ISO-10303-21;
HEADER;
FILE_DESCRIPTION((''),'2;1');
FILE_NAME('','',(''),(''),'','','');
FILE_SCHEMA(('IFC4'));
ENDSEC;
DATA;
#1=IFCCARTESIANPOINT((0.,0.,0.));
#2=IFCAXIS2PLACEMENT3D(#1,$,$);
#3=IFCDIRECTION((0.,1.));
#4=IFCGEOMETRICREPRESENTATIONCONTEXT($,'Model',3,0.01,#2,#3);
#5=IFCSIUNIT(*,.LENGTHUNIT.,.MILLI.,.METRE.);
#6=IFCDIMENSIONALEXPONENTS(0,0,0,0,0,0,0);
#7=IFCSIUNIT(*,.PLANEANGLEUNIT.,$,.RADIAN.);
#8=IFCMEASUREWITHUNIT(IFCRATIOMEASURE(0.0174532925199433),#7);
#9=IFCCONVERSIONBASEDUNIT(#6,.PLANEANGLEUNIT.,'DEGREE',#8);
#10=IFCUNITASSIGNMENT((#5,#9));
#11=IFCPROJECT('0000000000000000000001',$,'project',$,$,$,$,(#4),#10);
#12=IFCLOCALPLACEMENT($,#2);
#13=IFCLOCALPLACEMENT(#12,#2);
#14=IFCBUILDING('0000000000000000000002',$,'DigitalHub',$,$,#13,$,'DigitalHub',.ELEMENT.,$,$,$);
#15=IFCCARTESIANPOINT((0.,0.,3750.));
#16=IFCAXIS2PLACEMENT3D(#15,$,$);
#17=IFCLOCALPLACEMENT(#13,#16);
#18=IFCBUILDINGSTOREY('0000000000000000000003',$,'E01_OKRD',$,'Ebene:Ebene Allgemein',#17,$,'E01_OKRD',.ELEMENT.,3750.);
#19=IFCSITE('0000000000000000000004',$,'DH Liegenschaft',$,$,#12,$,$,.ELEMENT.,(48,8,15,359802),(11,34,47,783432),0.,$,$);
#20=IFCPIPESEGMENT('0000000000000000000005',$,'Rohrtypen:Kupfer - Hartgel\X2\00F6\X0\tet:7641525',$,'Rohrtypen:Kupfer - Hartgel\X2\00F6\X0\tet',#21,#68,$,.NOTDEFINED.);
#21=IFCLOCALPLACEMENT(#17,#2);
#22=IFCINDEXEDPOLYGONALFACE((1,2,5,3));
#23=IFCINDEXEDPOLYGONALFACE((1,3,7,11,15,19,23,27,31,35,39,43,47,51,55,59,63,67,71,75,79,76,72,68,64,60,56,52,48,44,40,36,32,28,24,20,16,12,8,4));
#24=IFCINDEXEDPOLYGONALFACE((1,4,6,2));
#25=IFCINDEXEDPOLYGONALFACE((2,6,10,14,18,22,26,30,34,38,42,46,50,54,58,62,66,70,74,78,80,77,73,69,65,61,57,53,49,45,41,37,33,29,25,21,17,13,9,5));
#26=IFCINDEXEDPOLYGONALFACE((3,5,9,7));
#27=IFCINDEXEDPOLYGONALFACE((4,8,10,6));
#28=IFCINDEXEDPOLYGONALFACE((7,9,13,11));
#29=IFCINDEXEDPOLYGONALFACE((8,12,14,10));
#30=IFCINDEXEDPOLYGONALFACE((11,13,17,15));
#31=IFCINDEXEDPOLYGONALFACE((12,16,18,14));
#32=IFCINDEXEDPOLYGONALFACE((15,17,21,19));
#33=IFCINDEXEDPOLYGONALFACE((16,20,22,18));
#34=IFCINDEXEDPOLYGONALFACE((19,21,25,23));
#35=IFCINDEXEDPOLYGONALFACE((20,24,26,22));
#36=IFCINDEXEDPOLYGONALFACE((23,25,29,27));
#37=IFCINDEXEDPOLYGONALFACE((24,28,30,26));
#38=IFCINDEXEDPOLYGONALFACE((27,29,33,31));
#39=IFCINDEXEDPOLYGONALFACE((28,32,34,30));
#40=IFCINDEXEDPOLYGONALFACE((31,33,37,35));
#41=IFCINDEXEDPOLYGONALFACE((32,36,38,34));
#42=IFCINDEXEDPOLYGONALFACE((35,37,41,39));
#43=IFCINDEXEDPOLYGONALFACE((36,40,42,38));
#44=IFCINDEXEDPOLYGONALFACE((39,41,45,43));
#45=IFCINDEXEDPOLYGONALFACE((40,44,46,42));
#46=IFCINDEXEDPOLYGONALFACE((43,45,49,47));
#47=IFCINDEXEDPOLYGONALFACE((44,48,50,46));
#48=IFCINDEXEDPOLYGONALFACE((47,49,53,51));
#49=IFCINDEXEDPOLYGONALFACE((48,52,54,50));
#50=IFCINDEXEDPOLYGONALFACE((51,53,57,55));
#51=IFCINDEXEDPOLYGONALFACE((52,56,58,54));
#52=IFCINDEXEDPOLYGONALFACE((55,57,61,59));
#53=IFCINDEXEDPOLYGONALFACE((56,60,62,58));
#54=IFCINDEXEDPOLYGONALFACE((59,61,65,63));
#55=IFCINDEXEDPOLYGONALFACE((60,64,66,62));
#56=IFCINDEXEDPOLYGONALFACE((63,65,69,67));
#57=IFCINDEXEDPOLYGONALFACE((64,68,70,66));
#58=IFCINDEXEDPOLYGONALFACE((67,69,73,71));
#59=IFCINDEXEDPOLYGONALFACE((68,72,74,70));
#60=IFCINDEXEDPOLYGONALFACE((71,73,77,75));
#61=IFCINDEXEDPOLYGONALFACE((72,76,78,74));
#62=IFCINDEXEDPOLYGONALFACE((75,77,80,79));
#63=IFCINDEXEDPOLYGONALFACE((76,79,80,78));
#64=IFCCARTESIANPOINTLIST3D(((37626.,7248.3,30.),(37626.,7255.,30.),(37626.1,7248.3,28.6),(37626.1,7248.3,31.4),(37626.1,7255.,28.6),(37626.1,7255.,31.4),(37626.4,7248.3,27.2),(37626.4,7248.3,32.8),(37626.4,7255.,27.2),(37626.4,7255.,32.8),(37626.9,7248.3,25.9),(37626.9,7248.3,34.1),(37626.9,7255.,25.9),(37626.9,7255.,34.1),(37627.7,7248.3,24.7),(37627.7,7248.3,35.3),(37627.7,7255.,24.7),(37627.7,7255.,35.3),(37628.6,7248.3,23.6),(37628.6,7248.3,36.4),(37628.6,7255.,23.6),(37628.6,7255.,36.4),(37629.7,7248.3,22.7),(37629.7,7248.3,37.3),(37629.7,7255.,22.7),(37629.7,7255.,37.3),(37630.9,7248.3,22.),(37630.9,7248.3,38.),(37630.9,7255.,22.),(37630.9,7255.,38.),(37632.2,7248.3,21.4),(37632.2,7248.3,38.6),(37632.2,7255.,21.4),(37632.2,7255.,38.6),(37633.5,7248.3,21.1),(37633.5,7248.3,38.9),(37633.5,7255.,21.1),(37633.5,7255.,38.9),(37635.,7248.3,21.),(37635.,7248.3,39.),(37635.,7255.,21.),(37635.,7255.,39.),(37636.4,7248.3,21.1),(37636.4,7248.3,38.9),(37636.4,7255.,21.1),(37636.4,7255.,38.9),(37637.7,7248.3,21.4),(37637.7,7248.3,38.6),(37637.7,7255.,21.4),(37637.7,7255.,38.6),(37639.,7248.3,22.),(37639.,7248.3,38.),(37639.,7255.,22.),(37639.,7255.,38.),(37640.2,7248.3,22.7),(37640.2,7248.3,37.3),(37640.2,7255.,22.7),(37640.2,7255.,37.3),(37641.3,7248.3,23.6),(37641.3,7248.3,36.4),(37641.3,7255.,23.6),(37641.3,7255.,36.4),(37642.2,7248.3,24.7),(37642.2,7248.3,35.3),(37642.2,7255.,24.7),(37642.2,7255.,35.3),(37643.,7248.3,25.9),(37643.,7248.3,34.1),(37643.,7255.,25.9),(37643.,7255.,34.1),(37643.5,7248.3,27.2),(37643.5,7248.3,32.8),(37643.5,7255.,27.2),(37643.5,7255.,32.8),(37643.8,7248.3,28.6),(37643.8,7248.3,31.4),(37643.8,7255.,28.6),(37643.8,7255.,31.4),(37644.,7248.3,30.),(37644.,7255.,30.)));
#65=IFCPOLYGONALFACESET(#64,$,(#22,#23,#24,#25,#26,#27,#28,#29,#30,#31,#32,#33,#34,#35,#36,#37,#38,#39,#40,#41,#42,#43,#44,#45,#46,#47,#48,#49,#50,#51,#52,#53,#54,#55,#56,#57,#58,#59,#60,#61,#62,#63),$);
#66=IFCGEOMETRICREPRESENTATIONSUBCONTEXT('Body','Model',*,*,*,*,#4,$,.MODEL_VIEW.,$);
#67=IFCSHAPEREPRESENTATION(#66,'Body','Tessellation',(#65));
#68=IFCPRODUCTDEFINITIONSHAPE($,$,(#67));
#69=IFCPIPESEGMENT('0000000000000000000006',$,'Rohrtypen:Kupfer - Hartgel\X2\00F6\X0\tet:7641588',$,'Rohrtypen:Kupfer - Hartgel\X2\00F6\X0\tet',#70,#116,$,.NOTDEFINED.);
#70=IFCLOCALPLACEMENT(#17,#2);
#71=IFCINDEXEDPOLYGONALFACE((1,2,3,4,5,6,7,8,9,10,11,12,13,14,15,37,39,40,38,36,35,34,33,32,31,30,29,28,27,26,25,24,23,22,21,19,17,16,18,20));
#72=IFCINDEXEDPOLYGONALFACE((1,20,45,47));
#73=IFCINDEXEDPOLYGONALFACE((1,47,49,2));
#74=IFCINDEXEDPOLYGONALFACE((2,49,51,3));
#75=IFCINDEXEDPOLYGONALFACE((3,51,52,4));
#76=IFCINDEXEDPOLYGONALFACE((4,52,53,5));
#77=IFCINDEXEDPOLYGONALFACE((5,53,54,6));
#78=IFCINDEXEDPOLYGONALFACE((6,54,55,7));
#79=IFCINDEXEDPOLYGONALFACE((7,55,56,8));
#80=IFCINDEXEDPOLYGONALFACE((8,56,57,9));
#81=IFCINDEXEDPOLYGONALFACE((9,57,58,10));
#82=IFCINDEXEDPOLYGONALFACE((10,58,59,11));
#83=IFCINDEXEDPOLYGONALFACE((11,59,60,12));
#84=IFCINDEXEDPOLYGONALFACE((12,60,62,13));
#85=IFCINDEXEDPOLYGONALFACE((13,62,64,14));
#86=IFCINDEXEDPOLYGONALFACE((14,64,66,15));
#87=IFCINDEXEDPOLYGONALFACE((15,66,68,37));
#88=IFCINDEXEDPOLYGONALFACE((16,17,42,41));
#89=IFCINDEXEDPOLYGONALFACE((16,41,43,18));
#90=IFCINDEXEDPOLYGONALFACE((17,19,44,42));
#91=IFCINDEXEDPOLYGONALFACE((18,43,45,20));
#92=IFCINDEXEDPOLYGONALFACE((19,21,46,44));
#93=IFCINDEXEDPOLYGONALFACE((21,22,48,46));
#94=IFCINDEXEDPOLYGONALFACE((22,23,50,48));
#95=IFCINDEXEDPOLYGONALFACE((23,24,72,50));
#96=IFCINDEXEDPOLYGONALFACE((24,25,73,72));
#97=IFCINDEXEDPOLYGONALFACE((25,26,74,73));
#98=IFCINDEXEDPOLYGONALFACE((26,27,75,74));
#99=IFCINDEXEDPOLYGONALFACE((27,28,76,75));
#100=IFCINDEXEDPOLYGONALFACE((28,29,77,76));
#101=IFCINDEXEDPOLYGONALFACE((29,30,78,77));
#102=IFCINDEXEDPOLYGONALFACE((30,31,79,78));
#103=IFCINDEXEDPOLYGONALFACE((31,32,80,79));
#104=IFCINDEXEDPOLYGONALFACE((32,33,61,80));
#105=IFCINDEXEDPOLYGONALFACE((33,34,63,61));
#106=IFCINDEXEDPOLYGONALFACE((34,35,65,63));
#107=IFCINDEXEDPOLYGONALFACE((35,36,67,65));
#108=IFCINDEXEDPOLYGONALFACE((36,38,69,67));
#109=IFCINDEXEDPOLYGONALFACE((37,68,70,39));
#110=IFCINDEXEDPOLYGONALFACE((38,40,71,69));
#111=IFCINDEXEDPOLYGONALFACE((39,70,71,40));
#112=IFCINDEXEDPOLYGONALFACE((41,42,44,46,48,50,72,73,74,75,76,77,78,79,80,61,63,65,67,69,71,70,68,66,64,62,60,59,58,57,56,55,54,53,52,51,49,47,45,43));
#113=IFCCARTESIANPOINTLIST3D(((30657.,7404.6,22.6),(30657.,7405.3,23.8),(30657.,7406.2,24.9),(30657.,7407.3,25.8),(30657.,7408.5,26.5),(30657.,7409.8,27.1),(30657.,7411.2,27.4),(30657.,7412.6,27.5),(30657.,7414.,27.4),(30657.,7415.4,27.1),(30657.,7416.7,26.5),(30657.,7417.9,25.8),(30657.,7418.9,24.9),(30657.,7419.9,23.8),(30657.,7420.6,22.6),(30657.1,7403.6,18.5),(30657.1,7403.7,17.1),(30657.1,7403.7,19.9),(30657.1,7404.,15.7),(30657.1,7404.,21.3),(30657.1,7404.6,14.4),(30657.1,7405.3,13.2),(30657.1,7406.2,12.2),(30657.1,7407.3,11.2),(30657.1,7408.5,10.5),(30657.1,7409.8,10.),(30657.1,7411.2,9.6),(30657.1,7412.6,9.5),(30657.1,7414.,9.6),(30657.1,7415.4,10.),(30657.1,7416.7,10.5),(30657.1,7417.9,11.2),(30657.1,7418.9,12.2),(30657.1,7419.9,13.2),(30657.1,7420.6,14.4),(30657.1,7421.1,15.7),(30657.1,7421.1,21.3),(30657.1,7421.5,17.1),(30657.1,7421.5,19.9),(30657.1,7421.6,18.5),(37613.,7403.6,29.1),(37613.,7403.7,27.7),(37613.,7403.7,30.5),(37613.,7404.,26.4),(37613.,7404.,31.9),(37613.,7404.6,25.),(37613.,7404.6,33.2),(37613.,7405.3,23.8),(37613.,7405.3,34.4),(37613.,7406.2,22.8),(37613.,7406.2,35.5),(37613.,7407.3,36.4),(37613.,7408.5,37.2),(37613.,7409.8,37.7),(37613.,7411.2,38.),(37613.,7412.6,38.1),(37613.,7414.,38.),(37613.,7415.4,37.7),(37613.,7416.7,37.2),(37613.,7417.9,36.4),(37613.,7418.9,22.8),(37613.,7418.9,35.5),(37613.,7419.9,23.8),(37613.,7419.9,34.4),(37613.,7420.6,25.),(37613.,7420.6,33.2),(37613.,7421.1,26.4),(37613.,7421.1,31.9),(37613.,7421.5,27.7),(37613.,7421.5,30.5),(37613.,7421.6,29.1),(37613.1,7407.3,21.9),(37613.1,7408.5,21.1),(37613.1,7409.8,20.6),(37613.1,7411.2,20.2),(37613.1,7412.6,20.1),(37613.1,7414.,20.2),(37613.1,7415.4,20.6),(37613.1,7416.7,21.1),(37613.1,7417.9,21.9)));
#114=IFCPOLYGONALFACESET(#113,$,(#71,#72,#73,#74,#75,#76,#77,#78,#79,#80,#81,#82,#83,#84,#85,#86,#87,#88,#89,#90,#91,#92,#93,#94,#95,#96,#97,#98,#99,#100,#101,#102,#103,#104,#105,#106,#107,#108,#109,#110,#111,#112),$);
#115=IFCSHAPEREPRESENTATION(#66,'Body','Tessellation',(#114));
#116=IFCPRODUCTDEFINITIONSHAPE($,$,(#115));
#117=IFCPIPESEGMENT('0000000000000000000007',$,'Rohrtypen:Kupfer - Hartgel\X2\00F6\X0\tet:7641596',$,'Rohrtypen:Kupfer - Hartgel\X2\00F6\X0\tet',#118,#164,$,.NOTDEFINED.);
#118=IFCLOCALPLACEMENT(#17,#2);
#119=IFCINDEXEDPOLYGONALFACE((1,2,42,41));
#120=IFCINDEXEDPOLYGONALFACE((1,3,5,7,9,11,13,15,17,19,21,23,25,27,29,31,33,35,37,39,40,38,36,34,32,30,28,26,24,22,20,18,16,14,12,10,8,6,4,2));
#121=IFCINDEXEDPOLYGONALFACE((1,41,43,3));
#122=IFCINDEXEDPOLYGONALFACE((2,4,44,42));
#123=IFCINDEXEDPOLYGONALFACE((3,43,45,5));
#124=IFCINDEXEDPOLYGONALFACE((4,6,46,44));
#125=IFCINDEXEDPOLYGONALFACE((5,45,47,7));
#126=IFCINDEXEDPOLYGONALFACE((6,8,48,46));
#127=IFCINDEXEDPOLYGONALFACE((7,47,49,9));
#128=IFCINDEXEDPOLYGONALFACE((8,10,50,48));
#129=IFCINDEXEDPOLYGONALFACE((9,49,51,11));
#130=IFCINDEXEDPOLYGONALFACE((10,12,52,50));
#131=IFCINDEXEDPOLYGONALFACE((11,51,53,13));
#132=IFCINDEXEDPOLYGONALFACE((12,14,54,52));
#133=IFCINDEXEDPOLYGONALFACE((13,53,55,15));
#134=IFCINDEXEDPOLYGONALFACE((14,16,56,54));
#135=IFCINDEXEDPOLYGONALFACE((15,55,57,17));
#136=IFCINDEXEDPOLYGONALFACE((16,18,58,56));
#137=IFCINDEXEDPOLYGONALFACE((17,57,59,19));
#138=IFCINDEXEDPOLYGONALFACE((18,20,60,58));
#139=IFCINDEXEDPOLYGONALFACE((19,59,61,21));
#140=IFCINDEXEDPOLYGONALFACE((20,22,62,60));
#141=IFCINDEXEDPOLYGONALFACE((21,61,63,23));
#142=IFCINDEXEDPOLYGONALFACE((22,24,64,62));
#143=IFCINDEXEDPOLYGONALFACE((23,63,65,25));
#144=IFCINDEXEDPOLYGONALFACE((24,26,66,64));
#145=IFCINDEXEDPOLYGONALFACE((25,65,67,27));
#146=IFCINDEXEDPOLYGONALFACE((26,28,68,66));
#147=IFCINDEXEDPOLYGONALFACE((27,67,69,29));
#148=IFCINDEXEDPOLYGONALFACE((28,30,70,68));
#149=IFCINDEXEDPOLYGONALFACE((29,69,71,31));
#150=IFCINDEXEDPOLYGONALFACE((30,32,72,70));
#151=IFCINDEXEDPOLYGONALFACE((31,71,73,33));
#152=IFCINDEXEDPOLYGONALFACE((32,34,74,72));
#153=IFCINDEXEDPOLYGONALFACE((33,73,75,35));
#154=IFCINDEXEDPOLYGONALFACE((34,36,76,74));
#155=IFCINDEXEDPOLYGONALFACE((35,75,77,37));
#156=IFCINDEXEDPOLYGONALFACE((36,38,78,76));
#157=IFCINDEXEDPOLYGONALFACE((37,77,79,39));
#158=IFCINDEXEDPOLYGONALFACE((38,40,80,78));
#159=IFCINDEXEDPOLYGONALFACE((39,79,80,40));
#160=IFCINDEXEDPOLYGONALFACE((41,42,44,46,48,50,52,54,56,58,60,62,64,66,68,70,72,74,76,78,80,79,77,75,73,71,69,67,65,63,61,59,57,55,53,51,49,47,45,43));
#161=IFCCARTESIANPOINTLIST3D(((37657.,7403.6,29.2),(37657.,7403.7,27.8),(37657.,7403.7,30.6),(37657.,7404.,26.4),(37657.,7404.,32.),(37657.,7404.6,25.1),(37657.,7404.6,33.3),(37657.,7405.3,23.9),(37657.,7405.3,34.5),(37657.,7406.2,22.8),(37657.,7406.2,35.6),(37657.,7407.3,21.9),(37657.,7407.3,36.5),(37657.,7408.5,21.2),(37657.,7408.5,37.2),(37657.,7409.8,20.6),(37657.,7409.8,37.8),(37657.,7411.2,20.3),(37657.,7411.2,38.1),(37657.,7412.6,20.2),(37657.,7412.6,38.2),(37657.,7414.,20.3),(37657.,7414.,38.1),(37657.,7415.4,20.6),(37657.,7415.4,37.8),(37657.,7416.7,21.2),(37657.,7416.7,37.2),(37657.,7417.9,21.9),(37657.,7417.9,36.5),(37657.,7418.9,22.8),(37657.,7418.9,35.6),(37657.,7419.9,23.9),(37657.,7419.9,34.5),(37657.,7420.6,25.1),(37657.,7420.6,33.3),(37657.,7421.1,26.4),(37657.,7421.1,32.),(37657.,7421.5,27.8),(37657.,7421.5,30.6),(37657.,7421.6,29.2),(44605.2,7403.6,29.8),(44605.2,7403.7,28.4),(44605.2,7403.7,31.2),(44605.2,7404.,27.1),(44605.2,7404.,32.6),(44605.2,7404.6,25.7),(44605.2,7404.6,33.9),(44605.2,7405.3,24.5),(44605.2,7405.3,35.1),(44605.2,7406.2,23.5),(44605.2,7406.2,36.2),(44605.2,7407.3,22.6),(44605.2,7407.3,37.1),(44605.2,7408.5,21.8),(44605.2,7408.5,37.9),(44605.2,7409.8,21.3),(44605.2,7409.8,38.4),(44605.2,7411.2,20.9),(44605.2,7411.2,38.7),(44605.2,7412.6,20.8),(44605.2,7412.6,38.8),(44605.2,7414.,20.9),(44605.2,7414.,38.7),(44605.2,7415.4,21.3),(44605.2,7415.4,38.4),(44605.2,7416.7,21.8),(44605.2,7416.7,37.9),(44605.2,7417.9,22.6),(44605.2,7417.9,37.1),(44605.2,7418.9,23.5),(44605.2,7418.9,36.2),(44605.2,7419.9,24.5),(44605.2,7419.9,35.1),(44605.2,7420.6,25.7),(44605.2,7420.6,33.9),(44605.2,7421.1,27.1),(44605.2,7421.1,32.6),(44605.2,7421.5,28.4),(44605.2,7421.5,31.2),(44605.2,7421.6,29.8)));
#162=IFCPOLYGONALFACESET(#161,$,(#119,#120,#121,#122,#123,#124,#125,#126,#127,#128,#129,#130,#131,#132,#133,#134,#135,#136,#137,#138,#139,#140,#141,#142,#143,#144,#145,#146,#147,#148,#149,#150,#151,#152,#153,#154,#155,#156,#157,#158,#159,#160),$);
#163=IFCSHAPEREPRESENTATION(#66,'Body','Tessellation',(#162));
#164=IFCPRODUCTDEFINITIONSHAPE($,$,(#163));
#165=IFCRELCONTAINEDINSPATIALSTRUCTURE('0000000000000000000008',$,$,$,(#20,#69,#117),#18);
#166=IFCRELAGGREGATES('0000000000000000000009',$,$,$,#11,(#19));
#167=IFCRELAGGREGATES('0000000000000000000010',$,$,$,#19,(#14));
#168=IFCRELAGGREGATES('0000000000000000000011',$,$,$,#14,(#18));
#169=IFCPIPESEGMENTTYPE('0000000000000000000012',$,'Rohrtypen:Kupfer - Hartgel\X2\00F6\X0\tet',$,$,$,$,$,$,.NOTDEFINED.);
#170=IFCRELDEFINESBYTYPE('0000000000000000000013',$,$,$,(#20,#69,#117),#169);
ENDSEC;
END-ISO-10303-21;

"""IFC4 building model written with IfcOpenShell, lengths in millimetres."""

from ifc_helpers import new_model, entity, si_unit, converted_unit, direction, frame, origin, place, context, subcontext, project, spatial, indexed_curve, outline, extrude, type_object, element, save


model = new_model("IFC4")

# Units and contexts
model_context = context("Model", 3, precision=0.01, world=origin(), true_north=direction((0.0, 1.0)))
body_context = subcontext(model_context, "Body", "Model", "MODEL_VIEW")
ifc_project = project(units=[si_unit("LENGTHUNIT", "METRE", prefix="MILLI"), converted_unit("PLANEANGLEUNIT", "DEGREE", entity("IfcRatioMeasure", 0.0174532925199433), si_unit("PLANEANGLEUNIT", "RADIAN"), dimensions=[0, 0, 0, 0, 0, 0, 0])], contexts=[model_context])

# Site, building, storey
site_placement = place(None, origin())
site = spatial("IfcSite", under=ifc_project, at=site_placement, Name="DH Liegenschaft", CompositionType="ELEMENT", RefLatitude=(48, 8, 15, 359802), RefLongitude=(11, 34, 47, 783432), RefElevation=0.0)
building_placement = place(site_placement, origin())
building = spatial("IfcBuilding", under=site, at=building_placement, Name="DigitalHub", LongName="DigitalHub", CompositionType="ELEMENT")
storey_placement = place(building_placement, frame((0.0, 0.0, 3750.0)))
storey = spatial("IfcBuildingStorey", under=building, at=storey_placement, Name="E01_OKRD", ObjectType="Ebene:Ebene Allgemein", LongName="E01_OKRD", CompositionType="ELEMENT", Elevation=3750.0)

# Pipe segments
pipe_segment_type = type_object("IfcPipeSegmentType", Name="Rohrtypen:Kupfer - Hartgelötet", PredefinedType="NOTDEFINED")
pipe_segment_1_placement = place(storey_placement, frame((37624.4, 7248.3, 19.4)))
element("IfcPipeSegment", 1, at=pipe_segment_1_placement, inside=storey, type_object=pipe_segment_type, Name="Rohrtypen:Kupfer - Hartgelötet:7641525", ObjectType="Rohrtypen:Kupfer - Hartgelötet", PredefinedType="NOTDEFINED", context=body_context, shape_type="SweptSolid", body=[
    extrude(outline(indexed_curve([(9.0, 0.0), (8.9, 1.4), (8.6, 2.8), (8.0, 4.1), (7.3, 5.3), (6.4, 6.4), (5.3, 7.3), (4.1, 8.0), (2.8, 8.6), (1.4, 8.9), (0.0, 9.0), (-1.4, 8.9), (-2.8, 8.6), (-4.1, 8.0), (-5.3, 7.3), (-6.4, 6.4), (-7.3, 5.3), (-8.0, 4.1), (-8.6, 2.8), (-8.9, 1.4), (-9.0, 0.0), (-8.9, -1.4), (-8.6, -2.8), (-8.0, -4.1), (-7.3, -5.3), (-6.4, -6.4), (-5.3, -7.3), (-4.1, -8.0), (-2.8, -8.6), (-1.4, -8.9), (0.0, -9.0), (1.4, -8.9), (2.8, -8.6), (4.1, -8.0), (5.3, -7.3), (6.4, -6.4), (7.3, -5.3), (8.0, -4.1), (8.6, -2.8), (8.9, -1.4), (9.0, 0.0)], self_intersect=False)), frame((10.6, 0.0, 10.6), z_axis=(0.000051, 1.0, 0.0), x_axis=(1.0, -0.000051, 0.0)), (0.0, 0.0, 1.0), 6.6),
])
pipe_segment_2_placement = place(storey_placement, frame((30657.0, 7402.0, 7.9)))
element("IfcPipeSegment", 2, at=pipe_segment_2_placement, inside=storey, type_object=pipe_segment_type, Name="Rohrtypen:Kupfer - Hartgelötet:7641588", ObjectType="Rohrtypen:Kupfer - Hartgelötet", PredefinedType="NOTDEFINED", context=body_context, shape_type="SweptSolid", body=[
    extrude(outline(indexed_curve([(9.0, 0.0), (8.9, 1.4), (8.6, 2.8), (8.0, 4.1), (7.3, 5.3), (6.4, 6.4), (5.3, 7.3), (4.1, 8.0), (2.8, 8.6), (1.4, 8.9), (0.0, 9.0), (-1.4, 8.9), (-2.8, 8.6), (-4.1, 8.0), (-5.3, 7.3), (-6.4, 6.4), (-7.3, 5.3), (-8.0, 4.1), (-8.6, 2.8), (-8.9, 1.4), (-9.0, 0.0), (-8.9, -1.4), (-8.6, -2.8), (-8.0, -4.1), (-7.3, -5.3), (-6.4, -6.4), (-5.3, -7.3), (-4.1, -8.0), (-2.8, -8.6), (-1.4, -8.9), (0.0, -9.0), (1.4, -8.9), (2.8, -8.6), (4.1, -8.0), (5.3, -7.3), (6.4, -6.4), (7.3, -5.3), (8.0, -4.1), (8.6, -2.8), (8.9, -1.4), (9.0, 0.0)], self_intersect=False)), frame((0.0, 10.6, 10.6), z_axis=(0.999999, 0.0, 0.001525), x_axis=(0.0, -1.0, 0.0)), (0.0, 0.0, 1.0), 6956.0),
])
pipe_segment_3_placement = place(storey_placement, frame((37657.0, 7402.0, 18.6)))
element("IfcPipeSegment", 3, at=pipe_segment_3_placement, inside=storey, type_object=pipe_segment_type, Name="Rohrtypen:Kupfer - Hartgelötet:7641596", ObjectType="Rohrtypen:Kupfer - Hartgelötet", PredefinedType="NOTDEFINED", context=body_context, shape_type="SweptSolid", body=[
    extrude(outline(indexed_curve([(9.0, 0.0), (8.9, 1.4), (8.6, 2.8), (8.0, 4.1), (7.3, 5.3), (6.4, 6.4), (5.3, 7.3), (4.1, 8.0), (2.8, 8.6), (1.4, 8.9), (0.0, 9.0), (-1.4, 8.9), (-2.8, 8.6), (-4.1, 8.0), (-5.3, 7.3), (-6.4, 6.4), (-7.3, 5.3), (-8.0, 4.1), (-8.6, 2.8), (-8.9, 1.4), (-9.0, 0.0), (-8.9, -1.4), (-8.6, -2.8), (-8.0, -4.1), (-7.3, -5.3), (-6.4, -6.4), (-5.3, -7.3), (-4.1, -8.0), (-2.8, -8.6), (-1.4, -8.9), (0.0, -9.0), (1.4, -8.9), (2.8, -8.6), (4.1, -8.0), (5.3, -7.3), (6.4, -6.4), (7.3, -5.3), (8.0, -4.1), (8.6, -2.8), (8.9, -1.4), (9.0, 0.0)], self_intersect=False)), frame((0.0, 10.6, 10.6), z_axis=(1.0, 0.0, 0.000091), x_axis=(0.0, -1.0, 0.0)), (0.0, 0.0, 1.0), 6948.2),
])

save(model, "model.ifc")
